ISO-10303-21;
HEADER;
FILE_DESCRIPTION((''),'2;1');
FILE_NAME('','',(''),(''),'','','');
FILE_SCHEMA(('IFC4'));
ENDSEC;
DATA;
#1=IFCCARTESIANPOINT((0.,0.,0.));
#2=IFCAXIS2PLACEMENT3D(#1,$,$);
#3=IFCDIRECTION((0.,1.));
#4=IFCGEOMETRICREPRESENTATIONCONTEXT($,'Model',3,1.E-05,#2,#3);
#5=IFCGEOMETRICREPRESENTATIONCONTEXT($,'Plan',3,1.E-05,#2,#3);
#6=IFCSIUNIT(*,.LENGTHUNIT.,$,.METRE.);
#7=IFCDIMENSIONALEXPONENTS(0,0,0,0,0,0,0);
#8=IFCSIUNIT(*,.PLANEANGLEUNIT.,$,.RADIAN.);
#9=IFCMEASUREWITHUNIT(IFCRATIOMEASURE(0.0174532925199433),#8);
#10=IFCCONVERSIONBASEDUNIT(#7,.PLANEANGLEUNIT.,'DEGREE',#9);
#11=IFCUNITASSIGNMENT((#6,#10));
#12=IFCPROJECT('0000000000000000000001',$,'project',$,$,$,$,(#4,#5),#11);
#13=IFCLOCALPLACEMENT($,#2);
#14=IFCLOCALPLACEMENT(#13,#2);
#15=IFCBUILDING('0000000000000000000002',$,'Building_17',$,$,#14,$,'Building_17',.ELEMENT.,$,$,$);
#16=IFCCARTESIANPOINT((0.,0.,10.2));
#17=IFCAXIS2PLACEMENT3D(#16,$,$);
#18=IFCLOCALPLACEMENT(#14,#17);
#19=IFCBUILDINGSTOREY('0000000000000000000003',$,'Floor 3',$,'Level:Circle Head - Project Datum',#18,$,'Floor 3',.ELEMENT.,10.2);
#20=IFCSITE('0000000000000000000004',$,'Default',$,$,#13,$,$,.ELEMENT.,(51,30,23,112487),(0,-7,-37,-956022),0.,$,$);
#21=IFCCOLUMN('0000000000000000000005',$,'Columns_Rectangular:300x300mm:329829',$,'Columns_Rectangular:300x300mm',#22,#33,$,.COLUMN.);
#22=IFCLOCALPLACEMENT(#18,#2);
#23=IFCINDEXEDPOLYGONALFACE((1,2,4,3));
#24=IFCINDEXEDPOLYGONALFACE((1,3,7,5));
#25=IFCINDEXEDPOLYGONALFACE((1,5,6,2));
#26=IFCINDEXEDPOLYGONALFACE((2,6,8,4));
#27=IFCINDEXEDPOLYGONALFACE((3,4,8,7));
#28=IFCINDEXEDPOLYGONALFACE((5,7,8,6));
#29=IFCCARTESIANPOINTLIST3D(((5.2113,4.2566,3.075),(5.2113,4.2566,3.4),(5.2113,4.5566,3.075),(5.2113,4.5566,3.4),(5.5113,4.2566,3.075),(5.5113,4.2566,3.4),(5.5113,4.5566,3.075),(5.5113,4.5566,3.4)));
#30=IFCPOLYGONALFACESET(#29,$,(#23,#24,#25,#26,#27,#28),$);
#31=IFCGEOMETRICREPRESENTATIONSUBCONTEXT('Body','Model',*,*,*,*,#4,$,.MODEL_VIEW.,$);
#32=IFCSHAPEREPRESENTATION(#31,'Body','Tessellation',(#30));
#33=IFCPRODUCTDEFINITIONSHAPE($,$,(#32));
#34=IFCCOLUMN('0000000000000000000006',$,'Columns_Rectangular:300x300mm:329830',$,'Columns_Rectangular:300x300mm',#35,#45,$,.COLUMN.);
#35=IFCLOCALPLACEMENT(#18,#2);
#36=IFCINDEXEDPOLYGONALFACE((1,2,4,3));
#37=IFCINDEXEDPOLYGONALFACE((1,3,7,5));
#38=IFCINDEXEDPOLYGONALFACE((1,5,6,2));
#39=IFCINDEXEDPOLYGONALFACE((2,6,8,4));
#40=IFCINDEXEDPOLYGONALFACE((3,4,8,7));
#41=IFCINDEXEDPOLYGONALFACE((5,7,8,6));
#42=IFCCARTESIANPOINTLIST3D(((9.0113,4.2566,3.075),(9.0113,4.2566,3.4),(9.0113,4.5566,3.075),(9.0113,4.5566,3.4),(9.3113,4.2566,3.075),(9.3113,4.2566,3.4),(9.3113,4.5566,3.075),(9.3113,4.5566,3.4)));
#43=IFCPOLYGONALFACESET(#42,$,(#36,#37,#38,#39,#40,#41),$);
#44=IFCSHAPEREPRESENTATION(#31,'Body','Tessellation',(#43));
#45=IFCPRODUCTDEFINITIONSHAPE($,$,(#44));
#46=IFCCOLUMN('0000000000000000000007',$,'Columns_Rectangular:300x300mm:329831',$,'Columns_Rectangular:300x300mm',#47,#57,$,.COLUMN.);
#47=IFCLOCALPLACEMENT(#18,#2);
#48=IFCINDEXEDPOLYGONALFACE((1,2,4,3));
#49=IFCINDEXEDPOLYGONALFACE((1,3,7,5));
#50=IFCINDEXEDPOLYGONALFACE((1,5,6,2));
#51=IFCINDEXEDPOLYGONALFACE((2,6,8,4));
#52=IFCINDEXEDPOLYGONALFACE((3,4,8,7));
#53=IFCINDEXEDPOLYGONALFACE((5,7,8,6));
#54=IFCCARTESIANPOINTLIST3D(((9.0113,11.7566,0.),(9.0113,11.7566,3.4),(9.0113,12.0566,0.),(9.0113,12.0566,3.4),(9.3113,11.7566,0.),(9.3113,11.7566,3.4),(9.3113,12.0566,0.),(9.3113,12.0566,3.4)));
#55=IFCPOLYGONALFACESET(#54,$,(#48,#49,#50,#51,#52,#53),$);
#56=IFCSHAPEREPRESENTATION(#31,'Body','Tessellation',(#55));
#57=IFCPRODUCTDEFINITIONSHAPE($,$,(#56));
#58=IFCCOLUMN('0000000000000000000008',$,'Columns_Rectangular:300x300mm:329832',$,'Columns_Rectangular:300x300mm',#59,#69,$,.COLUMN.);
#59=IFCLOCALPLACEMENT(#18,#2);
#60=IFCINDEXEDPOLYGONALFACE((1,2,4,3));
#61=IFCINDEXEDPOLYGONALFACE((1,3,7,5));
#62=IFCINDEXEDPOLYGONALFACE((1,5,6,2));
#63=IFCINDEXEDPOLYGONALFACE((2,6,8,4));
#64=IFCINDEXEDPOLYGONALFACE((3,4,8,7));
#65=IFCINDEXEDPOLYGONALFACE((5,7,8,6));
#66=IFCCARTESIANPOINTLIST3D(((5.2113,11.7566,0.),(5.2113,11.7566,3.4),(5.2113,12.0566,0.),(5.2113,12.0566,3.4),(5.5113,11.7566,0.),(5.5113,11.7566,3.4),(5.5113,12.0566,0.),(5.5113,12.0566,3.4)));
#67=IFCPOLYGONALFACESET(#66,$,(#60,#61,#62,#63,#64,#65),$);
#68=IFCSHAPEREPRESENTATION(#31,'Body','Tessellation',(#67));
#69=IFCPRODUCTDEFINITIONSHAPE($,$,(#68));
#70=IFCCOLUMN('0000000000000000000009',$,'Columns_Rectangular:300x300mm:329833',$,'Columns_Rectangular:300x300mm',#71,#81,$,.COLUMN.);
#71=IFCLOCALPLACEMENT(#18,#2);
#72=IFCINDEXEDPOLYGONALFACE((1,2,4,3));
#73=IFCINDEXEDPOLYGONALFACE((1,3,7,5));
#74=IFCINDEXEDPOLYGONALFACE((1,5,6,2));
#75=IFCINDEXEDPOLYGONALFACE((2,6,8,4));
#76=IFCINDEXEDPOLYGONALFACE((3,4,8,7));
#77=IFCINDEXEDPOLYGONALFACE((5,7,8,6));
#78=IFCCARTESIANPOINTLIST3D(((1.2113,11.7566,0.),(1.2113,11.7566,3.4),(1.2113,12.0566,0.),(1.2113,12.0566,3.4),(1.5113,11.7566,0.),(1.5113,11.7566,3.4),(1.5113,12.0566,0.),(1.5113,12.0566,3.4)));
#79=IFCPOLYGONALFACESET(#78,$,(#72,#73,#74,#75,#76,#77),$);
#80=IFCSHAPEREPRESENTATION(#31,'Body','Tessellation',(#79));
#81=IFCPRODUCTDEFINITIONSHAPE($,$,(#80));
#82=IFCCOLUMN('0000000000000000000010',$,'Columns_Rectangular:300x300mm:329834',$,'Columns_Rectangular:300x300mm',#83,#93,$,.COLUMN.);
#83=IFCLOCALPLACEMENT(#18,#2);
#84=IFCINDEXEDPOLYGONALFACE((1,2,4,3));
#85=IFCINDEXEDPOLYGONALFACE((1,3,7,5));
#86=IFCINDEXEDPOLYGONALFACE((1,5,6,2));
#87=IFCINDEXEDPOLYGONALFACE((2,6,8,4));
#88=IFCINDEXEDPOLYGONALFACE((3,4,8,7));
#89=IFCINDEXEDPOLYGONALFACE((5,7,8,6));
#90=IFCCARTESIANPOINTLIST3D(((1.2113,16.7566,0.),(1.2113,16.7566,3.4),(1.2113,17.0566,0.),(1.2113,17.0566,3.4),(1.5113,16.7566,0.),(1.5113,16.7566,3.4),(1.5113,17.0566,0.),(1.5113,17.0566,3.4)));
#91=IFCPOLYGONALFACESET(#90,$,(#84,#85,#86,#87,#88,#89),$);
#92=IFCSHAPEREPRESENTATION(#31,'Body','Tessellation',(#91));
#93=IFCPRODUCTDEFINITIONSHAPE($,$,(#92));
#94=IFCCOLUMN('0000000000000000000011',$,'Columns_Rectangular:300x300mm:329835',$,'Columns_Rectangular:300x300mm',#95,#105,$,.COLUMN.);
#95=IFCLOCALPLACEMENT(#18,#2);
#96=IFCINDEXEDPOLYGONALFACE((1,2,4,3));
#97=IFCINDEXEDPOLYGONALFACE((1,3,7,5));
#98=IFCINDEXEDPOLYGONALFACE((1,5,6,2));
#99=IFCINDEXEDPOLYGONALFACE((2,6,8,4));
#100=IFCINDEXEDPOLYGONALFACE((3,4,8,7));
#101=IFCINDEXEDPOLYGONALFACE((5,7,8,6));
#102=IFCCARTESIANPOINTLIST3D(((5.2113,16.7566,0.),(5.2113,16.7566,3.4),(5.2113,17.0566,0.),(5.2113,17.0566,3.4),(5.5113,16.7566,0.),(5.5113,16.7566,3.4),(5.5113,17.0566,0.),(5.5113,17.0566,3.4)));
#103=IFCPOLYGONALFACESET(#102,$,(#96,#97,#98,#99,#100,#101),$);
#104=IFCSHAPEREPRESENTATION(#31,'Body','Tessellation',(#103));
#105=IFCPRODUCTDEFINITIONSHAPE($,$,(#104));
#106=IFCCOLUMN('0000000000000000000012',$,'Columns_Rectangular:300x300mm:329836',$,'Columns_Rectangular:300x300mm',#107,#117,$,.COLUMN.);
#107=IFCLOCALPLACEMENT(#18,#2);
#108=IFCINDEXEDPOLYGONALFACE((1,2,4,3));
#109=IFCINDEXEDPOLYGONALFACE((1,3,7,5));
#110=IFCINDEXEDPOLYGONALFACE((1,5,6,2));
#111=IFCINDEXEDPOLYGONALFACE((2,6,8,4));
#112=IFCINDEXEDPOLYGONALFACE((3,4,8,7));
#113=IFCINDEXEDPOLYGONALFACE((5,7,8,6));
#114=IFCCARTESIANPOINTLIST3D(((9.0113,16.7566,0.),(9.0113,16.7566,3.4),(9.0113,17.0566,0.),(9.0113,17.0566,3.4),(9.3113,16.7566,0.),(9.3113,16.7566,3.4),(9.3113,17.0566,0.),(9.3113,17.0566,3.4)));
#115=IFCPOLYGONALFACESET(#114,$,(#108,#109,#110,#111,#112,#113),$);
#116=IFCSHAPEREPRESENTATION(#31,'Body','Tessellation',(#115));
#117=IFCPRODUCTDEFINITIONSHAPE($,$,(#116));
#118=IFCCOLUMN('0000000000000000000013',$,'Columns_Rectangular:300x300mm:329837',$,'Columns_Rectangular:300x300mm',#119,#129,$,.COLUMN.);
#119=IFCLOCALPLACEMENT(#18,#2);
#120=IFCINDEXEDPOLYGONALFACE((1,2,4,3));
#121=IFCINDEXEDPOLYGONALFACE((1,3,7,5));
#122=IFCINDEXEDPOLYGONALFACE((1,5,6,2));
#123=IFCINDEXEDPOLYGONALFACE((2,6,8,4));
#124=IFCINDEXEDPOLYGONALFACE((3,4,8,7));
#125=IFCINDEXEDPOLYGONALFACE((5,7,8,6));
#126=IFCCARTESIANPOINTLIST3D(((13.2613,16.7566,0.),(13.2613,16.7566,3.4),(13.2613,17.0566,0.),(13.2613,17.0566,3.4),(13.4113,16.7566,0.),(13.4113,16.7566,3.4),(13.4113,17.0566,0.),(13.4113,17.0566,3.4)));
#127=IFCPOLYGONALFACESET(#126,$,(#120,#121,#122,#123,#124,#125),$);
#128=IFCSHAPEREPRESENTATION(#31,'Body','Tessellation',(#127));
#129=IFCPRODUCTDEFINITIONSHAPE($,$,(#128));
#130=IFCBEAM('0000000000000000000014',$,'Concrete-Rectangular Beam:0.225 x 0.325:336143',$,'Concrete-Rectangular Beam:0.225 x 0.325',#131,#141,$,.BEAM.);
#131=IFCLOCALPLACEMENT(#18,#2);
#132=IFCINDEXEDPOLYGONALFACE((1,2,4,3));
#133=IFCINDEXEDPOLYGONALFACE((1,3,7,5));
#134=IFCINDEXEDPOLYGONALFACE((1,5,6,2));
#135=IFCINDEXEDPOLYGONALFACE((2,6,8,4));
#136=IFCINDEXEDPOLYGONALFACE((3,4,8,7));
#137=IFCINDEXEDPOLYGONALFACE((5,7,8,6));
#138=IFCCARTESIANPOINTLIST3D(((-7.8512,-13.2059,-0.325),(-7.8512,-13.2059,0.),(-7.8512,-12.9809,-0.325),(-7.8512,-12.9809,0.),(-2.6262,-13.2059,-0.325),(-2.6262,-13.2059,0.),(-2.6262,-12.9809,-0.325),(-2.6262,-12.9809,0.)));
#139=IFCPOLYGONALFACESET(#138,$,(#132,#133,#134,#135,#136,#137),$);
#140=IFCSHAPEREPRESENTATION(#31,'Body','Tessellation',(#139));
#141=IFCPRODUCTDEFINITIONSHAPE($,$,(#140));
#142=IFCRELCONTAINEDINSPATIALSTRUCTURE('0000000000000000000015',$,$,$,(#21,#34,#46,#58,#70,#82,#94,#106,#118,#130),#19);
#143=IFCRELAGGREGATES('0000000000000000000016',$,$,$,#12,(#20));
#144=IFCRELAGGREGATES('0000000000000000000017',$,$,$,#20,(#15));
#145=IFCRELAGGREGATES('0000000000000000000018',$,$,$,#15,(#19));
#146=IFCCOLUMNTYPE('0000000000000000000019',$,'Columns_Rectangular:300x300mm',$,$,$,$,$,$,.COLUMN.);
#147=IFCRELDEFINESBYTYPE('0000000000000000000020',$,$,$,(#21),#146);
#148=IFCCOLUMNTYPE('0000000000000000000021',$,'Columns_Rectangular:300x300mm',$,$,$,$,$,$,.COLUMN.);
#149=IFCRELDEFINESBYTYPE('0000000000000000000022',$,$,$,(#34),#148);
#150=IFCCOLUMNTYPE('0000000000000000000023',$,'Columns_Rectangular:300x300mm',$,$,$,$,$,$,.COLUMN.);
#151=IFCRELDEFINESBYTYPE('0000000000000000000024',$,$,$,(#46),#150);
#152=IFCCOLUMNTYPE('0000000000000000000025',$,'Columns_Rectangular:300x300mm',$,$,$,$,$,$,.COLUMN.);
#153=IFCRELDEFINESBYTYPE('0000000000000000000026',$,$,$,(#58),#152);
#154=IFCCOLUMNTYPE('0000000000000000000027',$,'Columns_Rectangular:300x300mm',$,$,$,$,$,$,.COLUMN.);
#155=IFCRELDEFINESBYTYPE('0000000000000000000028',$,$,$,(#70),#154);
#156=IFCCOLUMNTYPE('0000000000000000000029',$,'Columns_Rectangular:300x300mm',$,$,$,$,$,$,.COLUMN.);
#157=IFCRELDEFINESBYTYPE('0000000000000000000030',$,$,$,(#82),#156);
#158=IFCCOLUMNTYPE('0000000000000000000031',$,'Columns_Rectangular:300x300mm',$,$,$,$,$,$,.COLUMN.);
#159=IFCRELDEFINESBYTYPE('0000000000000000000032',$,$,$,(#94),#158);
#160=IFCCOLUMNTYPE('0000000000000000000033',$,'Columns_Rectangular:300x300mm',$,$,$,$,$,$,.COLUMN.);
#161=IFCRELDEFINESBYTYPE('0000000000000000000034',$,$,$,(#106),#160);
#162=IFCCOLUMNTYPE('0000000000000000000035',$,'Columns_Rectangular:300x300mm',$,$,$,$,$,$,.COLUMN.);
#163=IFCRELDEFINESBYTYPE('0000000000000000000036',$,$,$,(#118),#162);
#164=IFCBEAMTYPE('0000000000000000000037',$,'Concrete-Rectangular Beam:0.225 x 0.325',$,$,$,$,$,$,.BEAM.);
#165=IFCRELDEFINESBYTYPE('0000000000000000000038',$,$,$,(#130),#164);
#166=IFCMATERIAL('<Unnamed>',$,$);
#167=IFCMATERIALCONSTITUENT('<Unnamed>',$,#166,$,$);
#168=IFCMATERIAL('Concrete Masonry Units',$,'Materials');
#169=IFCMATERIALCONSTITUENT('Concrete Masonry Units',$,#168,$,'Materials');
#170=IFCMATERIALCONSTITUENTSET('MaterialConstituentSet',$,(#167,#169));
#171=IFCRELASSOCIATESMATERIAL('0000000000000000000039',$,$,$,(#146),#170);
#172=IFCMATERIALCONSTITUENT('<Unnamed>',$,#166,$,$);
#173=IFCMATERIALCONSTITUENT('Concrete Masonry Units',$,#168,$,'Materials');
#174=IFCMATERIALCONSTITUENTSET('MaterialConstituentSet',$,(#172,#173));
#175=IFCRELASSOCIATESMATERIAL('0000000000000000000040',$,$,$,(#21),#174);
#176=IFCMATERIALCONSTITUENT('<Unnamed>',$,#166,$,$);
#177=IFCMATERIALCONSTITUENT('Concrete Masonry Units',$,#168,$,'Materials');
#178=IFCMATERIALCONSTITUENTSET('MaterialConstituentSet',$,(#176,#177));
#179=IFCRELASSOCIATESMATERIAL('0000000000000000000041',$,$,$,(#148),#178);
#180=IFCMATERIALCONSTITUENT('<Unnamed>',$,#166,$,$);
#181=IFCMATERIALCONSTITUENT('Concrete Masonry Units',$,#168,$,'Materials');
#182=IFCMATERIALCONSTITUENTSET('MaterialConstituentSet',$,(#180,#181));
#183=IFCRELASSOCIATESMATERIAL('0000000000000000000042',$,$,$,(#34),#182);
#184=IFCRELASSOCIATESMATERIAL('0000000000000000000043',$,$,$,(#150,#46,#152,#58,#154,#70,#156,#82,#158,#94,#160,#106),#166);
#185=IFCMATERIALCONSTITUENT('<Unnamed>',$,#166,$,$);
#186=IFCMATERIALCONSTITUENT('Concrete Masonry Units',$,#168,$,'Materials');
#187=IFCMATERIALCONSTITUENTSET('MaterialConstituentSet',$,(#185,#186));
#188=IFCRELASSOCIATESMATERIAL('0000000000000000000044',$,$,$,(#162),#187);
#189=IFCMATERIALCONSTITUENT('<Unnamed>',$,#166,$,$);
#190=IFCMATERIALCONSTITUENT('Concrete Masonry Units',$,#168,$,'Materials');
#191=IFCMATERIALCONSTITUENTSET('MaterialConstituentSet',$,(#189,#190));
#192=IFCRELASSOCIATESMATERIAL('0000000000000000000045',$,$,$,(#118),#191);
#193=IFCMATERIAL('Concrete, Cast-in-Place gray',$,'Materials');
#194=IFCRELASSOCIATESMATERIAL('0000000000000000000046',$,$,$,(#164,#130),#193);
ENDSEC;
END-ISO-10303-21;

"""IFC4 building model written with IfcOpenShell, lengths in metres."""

from ifc_helpers import new_model, entity, si_unit, converted_unit, direction, frame, origin, place, context, subcontext, project, spatial, indexed_curve, outline, extrude, source, transform, mapped, material, constituent, constituent_set, type_object, type_shapes, element, save


model = new_model("IFC4")

# Units and contexts
model_context = context("Model", 3, precision=1e-05, world=origin(), true_north=direction((0.0, 1.0)))
plan_context = context("Plan", 3, precision=1e-05, world=origin(), true_north=direction((0.0, 1.0)))
body_context = subcontext(model_context, "Body", "Model", "MODEL_VIEW")
ifc_project = project(units=[si_unit("LENGTHUNIT", "METRE"), converted_unit("PLANEANGLEUNIT", "DEGREE", entity("IfcRatioMeasure", 0.0174532925199433), si_unit("PLANEANGLEUNIT", "RADIAN"), dimensions=[0, 0, 0, 0, 0, 0, 0])], contexts=[model_context, plan_context])

# Site, building, storey
site_placement = place(None, origin())
site = spatial("IfcSite", under=ifc_project, at=site_placement, Name="Default", CompositionType="ELEMENT", RefLatitude=(51, 30, 23, 112487), RefLongitude=(0, -7, -37, -956022), RefElevation=0.0)
building_placement = place(site_placement, origin())
building = spatial("IfcBuilding", under=site, at=building_placement, Name="Building_17", LongName="Building_17", CompositionType="ELEMENT")
storey_placement = place(building_placement, frame((0.0, 0.0, 10.2)))
storey = spatial("IfcBuildingStorey", under=building, at=storey_placement, Name="Floor 3", ObjectType="Level:Circle Head - Project Datum", LongName="Floor 3", CompositionType="ELEMENT", Elevation=10.2)

# Columns
ifc_material_1 = material(Name="<Unnamed>")
ifc_material_2 = material(Name="Concrete Masonry Units", Category="Materials")
ifc_constituent_1 = constituent(ifc_material_1, Name="<Unnamed>")
ifc_constituent_2 = constituent(ifc_material_2, Name="Concrete Masonry Units", Category="Materials")
ifc_constituent_set_1 = constituent_set(constituents=[ifc_constituent_1, ifc_constituent_2], Name="MaterialConstituentSet")
ifc_constituent_3 = constituent(ifc_material_1, Name="<Unnamed>")
ifc_constituent_4 = constituent(ifc_material_2, Name="Concrete Masonry Units", Category="Materials")
ifc_constituent_set_2 = constituent_set(constituents=[ifc_constituent_3, ifc_constituent_4], Name="MaterialConstituentSet")
column_type_1 = type_object("IfcColumnType", Name="Columns_Rectangular:300x300mm", PredefinedType="COLUMN", material=ifc_constituent_set_2)
shared_shape_1 = source(origin(), body_context, "Body", "SweptSolid", [
    extrude(outline(indexed_curve([(-0.15, -0.15), (0.15, -0.15), (0.15, 0.15), (-0.15, 0.15), (-0.15, -0.15)], self_intersect=False)), frame((5.3613, 4.4066, 13.275), z_axis=(0.0, 0.0, 1.0), x_axis=(0.0, -1.0, 0.0)), (0.0, 0.0, 1.0), 0.325),
])
type_shapes(column_type_1, [shared_shape_1])
column_1_placement = place(storey_placement, frame((0.0, 0.0, -10.2)))
element("IfcColumn", 1, at=column_1_placement, inside=storey, type_object=column_type_1, material=ifc_constituent_set_1, Name="Columns_Rectangular:300x300mm:329829", ObjectType="Columns_Rectangular:300x300mm", PredefinedType="COLUMN", context=body_context, shape_type="MappedRepresentation", body=[
    mapped(shared_shape_1, transform((0.0, 0.0, 0.0), scale=1.0)),
])
ifc_constituent_5 = constituent(ifc_material_1, Name="<Unnamed>")
ifc_constituent_6 = constituent(ifc_material_2, Name="Concrete Masonry Units", Category="Materials")
ifc_constituent_set_3 = constituent_set(constituents=[ifc_constituent_5, ifc_constituent_6], Name="MaterialConstituentSet")
ifc_constituent_7 = constituent(ifc_material_1, Name="<Unnamed>")
ifc_constituent_8 = constituent(ifc_material_2, Name="Concrete Masonry Units", Category="Materials")
ifc_constituent_set_4 = constituent_set(constituents=[ifc_constituent_7, ifc_constituent_8], Name="MaterialConstituentSet")
column_type_2 = type_object("IfcColumnType", Name="Columns_Rectangular:300x300mm", PredefinedType="COLUMN", material=ifc_constituent_set_4)
shared_shape_2 = source(origin(), body_context, "Body", "SweptSolid", [
    extrude(outline(indexed_curve([(-0.15, -0.15), (0.15, -0.15), (0.15, 0.15), (-0.15, 0.15), (-0.15, -0.15)], self_intersect=False)), frame((9.1613, 4.4066, 13.275), z_axis=(0.0, 0.0, 1.0), x_axis=(0.0, -1.0, 0.0)), (0.0, 0.0, 1.0), 0.325),
])
type_shapes(column_type_2, [shared_shape_2])
column_2_placement = place(storey_placement, frame((0.0, 0.0, -10.2)))
element("IfcColumn", 2, at=column_2_placement, inside=storey, type_object=column_type_2, material=ifc_constituent_set_3, Name="Columns_Rectangular:300x300mm:329830", ObjectType="Columns_Rectangular:300x300mm", PredefinedType="COLUMN", context=body_context, shape_type="MappedRepresentation", body=[
    mapped(shared_shape_2, transform((0.0, 0.0, 0.0), scale=1.0)),
])
column_type_3 = type_object("IfcColumnType", Name="Columns_Rectangular:300x300mm", PredefinedType="COLUMN", material=ifc_material_1)
shared_shape_3 = source(origin(), body_context, "Body", "SweptSolid", [
    extrude(outline(indexed_curve([(-0.15, -0.15), (0.15, -0.15), (0.15, 0.15), (-0.15, 0.15), (-0.15, -0.15)], self_intersect=False)), frame((9.1613, 11.9066, 10.2), z_axis=(0.0, 0.0, 1.0), x_axis=(0.0, -1.0, 0.0)), (0.0, 0.0, 1.0), 3.4),
])
type_shapes(column_type_3, [shared_shape_3])
column_3_placement = place(storey_placement, frame((0.0, 0.0, -10.2)))
element("IfcColumn", 3, at=column_3_placement, inside=storey, type_object=column_type_3, material=ifc_material_1, Name="Columns_Rectangular:300x300mm:329831", ObjectType="Columns_Rectangular:300x300mm", PredefinedType="COLUMN", context=body_context, shape_type="MappedRepresentation", body=[
    mapped(shared_shape_3, transform((0.0, 0.0, 0.0), scale=1.0)),
])
column_type_4 = type_object("IfcColumnType", Name="Columns_Rectangular:300x300mm", PredefinedType="COLUMN", material=ifc_material_1)
shared_shape_4 = source(origin(), body_context, "Body", "SweptSolid", [
    extrude(outline(indexed_curve([(-0.15, -0.15), (0.15, -0.15), (0.15, 0.15), (-0.15, 0.15), (-0.15, -0.15)], self_intersect=False)), frame((5.3613, 11.9066, 10.2), z_axis=(0.0, 0.0, 1.0), x_axis=(0.0, -1.0, 0.0)), (0.0, 0.0, 1.0), 3.4),
])
type_shapes(column_type_4, [shared_shape_4])
column_4_placement = place(storey_placement, frame((0.0, 0.0, -10.2)))
element("IfcColumn", 4, at=column_4_placement, inside=storey, type_object=column_type_4, material=ifc_material_1, Name="Columns_Rectangular:300x300mm:329832", ObjectType="Columns_Rectangular:300x300mm", PredefinedType="COLUMN", context=body_context, shape_type="MappedRepresentation", body=[
    mapped(shared_shape_4, transform((0.0, 0.0, 0.0), scale=1.0)),
])
column_type_5 = type_object("IfcColumnType", Name="Columns_Rectangular:300x300mm", PredefinedType="COLUMN", material=ifc_material_1)
shared_shape_5 = source(origin(), body_context, "Body", "SweptSolid", [
    extrude(outline(indexed_curve([(-0.15, -0.15), (0.15, -0.15), (0.15, 0.15), (-0.15, 0.15), (-0.15, -0.15)], self_intersect=False)), frame((1.3613, 11.9066, 10.2), z_axis=(0.0, 0.0, 1.0), x_axis=(0.0, -1.0, 0.0)), (0.0, 0.0, 1.0), 3.4),
])
type_shapes(column_type_5, [shared_shape_5])
column_5_placement = place(storey_placement, frame((0.0, 0.0, -10.2)))
element("IfcColumn", 5, at=column_5_placement, inside=storey, type_object=column_type_5, material=ifc_material_1, Name="Columns_Rectangular:300x300mm:329833", ObjectType="Columns_Rectangular:300x300mm", PredefinedType="COLUMN", context=body_context, shape_type="MappedRepresentation", body=[
    mapped(shared_shape_5, transform((0.0, 0.0, 0.0), scale=1.0)),
])
column_type_6 = type_object("IfcColumnType", Name="Columns_Rectangular:300x300mm", PredefinedType="COLUMN", material=ifc_material_1)
shared_shape_6 = source(origin(), body_context, "Body", "SweptSolid", [
    extrude(outline(indexed_curve([(-0.15, -0.15), (0.15, -0.15), (0.15, 0.15), (-0.15, 0.15), (-0.15, -0.15)], self_intersect=False)), frame((1.3613, 16.9066, 10.2), z_axis=(0.0, 0.0, 1.0), x_axis=(0.0, -1.0, 0.0)), (0.0, 0.0, 1.0), 3.4),
])
type_shapes(column_type_6, [shared_shape_6])
column_6_placement = place(storey_placement, frame((0.0, 0.0, -10.2)))
element("IfcColumn", 6, at=column_6_placement, inside=storey, type_object=column_type_6, material=ifc_material_1, Name="Columns_Rectangular:300x300mm:329834", ObjectType="Columns_Rectangular:300x300mm", PredefinedType="COLUMN", context=body_context, shape_type="MappedRepresentation", body=[
    mapped(shared_shape_6, transform((0.0, 0.0, 0.0), scale=1.0)),
])
column_type_7 = type_object("IfcColumnType", Name="Columns_Rectangular:300x300mm", PredefinedType="COLUMN", material=ifc_material_1)
shared_shape_7 = source(origin(), body_context, "Body", "SweptSolid", [
    extrude(outline(indexed_curve([(-0.15, -0.15), (0.15, -0.15), (0.15, 0.15), (-0.15, 0.15), (-0.15, -0.15)], self_intersect=False)), frame((5.3613, 16.9066, 10.2), z_axis=(0.0, 0.0, 1.0), x_axis=(0.0, -1.0, 0.0)), (0.0, 0.0, 1.0), 3.4),
])
type_shapes(column_type_7, [shared_shape_7])
column_7_placement = place(storey_placement, frame((0.0, 0.0, -10.2)))
element("IfcColumn", 7, at=column_7_placement, inside=storey, type_object=column_type_7, material=ifc_material_1, Name="Columns_Rectangular:300x300mm:329835", ObjectType="Columns_Rectangular:300x300mm", PredefinedType="COLUMN", context=body_context, shape_type="MappedRepresentation", body=[
    mapped(shared_shape_7, transform((0.0, 0.0, 0.0), scale=1.0)),
])
column_type_8 = type_object("IfcColumnType", Name="Columns_Rectangular:300x300mm", PredefinedType="COLUMN", material=ifc_material_1)
shared_shape_8 = source(origin(), body_context, "Body", "SweptSolid", [
    extrude(outline(indexed_curve([(-0.15, -0.15), (0.15, -0.15), (0.15, 0.15), (-0.15, 0.15), (-0.15, -0.15)], self_intersect=False)), frame((9.1613, 16.9066, 10.2), z_axis=(0.0, 0.0, 1.0), x_axis=(0.0, -1.0, 0.0)), (0.0, 0.0, 1.0), 3.4),
])
type_shapes(column_type_8, [shared_shape_8])
column_8_placement = place(storey_placement, frame((0.0, 0.0, -10.2)))
element("IfcColumn", 8, at=column_8_placement, inside=storey, type_object=column_type_8, material=ifc_material_1, Name="Columns_Rectangular:300x300mm:329836", ObjectType="Columns_Rectangular:300x300mm", PredefinedType="COLUMN", context=body_context, shape_type="MappedRepresentation", body=[
    mapped(shared_shape_8, transform((0.0, 0.0, 0.0), scale=1.0)),
])
ifc_constituent_9 = constituent(ifc_material_1, Name="<Unnamed>")
ifc_constituent_10 = constituent(ifc_material_2, Name="Concrete Masonry Units", Category="Materials")
ifc_constituent_set_5 = constituent_set(constituents=[ifc_constituent_9, ifc_constituent_10], Name="MaterialConstituentSet")
ifc_constituent_11 = constituent(ifc_material_1, Name="<Unnamed>")
ifc_constituent_12 = constituent(ifc_material_2, Name="Concrete Masonry Units", Category="Materials")
ifc_constituent_set_6 = constituent_set(constituents=[ifc_constituent_11, ifc_constituent_12], Name="MaterialConstituentSet")
column_type_9 = type_object("IfcColumnType", Name="Columns_Rectangular:300x300mm", PredefinedType="COLUMN", material=ifc_constituent_set_6)
shared_shape_9 = source(origin(), body_context, "Body", "SweptSolid", [
    extrude(outline(indexed_curve([(-0.15, -0.075), (0.15, -0.075), (0.15, 0.075), (-0.15, 0.075), (-0.15, -0.075)], self_intersect=False)), frame((13.3363, 16.9066, 10.2), z_axis=(0.0, 0.0, 1.0), x_axis=(0.0, -1.0, 0.0)), (0.0, 0.0, 1.0), 3.4),
])
type_shapes(column_type_9, [shared_shape_9])
column_9_placement = place(storey_placement, frame((0.0, 0.0, -10.2)))
element("IfcColumn", 9, at=column_9_placement, inside=storey, type_object=column_type_9, material=ifc_constituent_set_5, Name="Columns_Rectangular:300x300mm:329837", ObjectType="Columns_Rectangular:300x300mm", PredefinedType="COLUMN", context=body_context, shape_type="MappedRepresentation", body=[
    mapped(shared_shape_9, transform((0.0, 0.0, 0.0), scale=1.0)),
])

# Beam
ifc_material_3 = material(Name="Concrete, Cast-in-Place gray", Category="Materials")
beam_type_1 = type_object("IfcBeamType", Name="Concrete-Rectangular Beam:0.225 x 0.325", PredefinedType="BEAM", material=ifc_material_3)
shared_shape_10 = source(origin(), body_context, "Body", "SweptSolid", [
    extrude(outline(indexed_curve([(-0.1625, -0.1125), (0.1625, -0.1125), (0.1625, 0.1125), (-0.1625, 0.1125), (-0.1625, -0.1125)], self_intersect=False)), frame((-7.8512, -13.0934, 10.0375), z_axis=(1.0, 0.0, 0.0), x_axis=(0.0, 0.0, -1.0)), (0.0, 0.0, 1.0), 5.225),
])
type_shapes(beam_type_1, [shared_shape_10])
beam_1_placement = place(storey_placement, frame((0.0, 0.0, -10.2)))
element("IfcBeam", 10, at=beam_1_placement, inside=storey, type_object=beam_type_1, material=ifc_material_3, Name="Concrete-Rectangular Beam:0.225 x 0.325:336143", ObjectType="Concrete-Rectangular Beam:0.225 x 0.325", PredefinedType="BEAM", context=body_context, shape_type="MappedRepresentation", body=[
    mapped(shared_shape_10, transform((0.0, 0.0, 0.0), scale=1.0)),
])

save(model, "model.ifc")
